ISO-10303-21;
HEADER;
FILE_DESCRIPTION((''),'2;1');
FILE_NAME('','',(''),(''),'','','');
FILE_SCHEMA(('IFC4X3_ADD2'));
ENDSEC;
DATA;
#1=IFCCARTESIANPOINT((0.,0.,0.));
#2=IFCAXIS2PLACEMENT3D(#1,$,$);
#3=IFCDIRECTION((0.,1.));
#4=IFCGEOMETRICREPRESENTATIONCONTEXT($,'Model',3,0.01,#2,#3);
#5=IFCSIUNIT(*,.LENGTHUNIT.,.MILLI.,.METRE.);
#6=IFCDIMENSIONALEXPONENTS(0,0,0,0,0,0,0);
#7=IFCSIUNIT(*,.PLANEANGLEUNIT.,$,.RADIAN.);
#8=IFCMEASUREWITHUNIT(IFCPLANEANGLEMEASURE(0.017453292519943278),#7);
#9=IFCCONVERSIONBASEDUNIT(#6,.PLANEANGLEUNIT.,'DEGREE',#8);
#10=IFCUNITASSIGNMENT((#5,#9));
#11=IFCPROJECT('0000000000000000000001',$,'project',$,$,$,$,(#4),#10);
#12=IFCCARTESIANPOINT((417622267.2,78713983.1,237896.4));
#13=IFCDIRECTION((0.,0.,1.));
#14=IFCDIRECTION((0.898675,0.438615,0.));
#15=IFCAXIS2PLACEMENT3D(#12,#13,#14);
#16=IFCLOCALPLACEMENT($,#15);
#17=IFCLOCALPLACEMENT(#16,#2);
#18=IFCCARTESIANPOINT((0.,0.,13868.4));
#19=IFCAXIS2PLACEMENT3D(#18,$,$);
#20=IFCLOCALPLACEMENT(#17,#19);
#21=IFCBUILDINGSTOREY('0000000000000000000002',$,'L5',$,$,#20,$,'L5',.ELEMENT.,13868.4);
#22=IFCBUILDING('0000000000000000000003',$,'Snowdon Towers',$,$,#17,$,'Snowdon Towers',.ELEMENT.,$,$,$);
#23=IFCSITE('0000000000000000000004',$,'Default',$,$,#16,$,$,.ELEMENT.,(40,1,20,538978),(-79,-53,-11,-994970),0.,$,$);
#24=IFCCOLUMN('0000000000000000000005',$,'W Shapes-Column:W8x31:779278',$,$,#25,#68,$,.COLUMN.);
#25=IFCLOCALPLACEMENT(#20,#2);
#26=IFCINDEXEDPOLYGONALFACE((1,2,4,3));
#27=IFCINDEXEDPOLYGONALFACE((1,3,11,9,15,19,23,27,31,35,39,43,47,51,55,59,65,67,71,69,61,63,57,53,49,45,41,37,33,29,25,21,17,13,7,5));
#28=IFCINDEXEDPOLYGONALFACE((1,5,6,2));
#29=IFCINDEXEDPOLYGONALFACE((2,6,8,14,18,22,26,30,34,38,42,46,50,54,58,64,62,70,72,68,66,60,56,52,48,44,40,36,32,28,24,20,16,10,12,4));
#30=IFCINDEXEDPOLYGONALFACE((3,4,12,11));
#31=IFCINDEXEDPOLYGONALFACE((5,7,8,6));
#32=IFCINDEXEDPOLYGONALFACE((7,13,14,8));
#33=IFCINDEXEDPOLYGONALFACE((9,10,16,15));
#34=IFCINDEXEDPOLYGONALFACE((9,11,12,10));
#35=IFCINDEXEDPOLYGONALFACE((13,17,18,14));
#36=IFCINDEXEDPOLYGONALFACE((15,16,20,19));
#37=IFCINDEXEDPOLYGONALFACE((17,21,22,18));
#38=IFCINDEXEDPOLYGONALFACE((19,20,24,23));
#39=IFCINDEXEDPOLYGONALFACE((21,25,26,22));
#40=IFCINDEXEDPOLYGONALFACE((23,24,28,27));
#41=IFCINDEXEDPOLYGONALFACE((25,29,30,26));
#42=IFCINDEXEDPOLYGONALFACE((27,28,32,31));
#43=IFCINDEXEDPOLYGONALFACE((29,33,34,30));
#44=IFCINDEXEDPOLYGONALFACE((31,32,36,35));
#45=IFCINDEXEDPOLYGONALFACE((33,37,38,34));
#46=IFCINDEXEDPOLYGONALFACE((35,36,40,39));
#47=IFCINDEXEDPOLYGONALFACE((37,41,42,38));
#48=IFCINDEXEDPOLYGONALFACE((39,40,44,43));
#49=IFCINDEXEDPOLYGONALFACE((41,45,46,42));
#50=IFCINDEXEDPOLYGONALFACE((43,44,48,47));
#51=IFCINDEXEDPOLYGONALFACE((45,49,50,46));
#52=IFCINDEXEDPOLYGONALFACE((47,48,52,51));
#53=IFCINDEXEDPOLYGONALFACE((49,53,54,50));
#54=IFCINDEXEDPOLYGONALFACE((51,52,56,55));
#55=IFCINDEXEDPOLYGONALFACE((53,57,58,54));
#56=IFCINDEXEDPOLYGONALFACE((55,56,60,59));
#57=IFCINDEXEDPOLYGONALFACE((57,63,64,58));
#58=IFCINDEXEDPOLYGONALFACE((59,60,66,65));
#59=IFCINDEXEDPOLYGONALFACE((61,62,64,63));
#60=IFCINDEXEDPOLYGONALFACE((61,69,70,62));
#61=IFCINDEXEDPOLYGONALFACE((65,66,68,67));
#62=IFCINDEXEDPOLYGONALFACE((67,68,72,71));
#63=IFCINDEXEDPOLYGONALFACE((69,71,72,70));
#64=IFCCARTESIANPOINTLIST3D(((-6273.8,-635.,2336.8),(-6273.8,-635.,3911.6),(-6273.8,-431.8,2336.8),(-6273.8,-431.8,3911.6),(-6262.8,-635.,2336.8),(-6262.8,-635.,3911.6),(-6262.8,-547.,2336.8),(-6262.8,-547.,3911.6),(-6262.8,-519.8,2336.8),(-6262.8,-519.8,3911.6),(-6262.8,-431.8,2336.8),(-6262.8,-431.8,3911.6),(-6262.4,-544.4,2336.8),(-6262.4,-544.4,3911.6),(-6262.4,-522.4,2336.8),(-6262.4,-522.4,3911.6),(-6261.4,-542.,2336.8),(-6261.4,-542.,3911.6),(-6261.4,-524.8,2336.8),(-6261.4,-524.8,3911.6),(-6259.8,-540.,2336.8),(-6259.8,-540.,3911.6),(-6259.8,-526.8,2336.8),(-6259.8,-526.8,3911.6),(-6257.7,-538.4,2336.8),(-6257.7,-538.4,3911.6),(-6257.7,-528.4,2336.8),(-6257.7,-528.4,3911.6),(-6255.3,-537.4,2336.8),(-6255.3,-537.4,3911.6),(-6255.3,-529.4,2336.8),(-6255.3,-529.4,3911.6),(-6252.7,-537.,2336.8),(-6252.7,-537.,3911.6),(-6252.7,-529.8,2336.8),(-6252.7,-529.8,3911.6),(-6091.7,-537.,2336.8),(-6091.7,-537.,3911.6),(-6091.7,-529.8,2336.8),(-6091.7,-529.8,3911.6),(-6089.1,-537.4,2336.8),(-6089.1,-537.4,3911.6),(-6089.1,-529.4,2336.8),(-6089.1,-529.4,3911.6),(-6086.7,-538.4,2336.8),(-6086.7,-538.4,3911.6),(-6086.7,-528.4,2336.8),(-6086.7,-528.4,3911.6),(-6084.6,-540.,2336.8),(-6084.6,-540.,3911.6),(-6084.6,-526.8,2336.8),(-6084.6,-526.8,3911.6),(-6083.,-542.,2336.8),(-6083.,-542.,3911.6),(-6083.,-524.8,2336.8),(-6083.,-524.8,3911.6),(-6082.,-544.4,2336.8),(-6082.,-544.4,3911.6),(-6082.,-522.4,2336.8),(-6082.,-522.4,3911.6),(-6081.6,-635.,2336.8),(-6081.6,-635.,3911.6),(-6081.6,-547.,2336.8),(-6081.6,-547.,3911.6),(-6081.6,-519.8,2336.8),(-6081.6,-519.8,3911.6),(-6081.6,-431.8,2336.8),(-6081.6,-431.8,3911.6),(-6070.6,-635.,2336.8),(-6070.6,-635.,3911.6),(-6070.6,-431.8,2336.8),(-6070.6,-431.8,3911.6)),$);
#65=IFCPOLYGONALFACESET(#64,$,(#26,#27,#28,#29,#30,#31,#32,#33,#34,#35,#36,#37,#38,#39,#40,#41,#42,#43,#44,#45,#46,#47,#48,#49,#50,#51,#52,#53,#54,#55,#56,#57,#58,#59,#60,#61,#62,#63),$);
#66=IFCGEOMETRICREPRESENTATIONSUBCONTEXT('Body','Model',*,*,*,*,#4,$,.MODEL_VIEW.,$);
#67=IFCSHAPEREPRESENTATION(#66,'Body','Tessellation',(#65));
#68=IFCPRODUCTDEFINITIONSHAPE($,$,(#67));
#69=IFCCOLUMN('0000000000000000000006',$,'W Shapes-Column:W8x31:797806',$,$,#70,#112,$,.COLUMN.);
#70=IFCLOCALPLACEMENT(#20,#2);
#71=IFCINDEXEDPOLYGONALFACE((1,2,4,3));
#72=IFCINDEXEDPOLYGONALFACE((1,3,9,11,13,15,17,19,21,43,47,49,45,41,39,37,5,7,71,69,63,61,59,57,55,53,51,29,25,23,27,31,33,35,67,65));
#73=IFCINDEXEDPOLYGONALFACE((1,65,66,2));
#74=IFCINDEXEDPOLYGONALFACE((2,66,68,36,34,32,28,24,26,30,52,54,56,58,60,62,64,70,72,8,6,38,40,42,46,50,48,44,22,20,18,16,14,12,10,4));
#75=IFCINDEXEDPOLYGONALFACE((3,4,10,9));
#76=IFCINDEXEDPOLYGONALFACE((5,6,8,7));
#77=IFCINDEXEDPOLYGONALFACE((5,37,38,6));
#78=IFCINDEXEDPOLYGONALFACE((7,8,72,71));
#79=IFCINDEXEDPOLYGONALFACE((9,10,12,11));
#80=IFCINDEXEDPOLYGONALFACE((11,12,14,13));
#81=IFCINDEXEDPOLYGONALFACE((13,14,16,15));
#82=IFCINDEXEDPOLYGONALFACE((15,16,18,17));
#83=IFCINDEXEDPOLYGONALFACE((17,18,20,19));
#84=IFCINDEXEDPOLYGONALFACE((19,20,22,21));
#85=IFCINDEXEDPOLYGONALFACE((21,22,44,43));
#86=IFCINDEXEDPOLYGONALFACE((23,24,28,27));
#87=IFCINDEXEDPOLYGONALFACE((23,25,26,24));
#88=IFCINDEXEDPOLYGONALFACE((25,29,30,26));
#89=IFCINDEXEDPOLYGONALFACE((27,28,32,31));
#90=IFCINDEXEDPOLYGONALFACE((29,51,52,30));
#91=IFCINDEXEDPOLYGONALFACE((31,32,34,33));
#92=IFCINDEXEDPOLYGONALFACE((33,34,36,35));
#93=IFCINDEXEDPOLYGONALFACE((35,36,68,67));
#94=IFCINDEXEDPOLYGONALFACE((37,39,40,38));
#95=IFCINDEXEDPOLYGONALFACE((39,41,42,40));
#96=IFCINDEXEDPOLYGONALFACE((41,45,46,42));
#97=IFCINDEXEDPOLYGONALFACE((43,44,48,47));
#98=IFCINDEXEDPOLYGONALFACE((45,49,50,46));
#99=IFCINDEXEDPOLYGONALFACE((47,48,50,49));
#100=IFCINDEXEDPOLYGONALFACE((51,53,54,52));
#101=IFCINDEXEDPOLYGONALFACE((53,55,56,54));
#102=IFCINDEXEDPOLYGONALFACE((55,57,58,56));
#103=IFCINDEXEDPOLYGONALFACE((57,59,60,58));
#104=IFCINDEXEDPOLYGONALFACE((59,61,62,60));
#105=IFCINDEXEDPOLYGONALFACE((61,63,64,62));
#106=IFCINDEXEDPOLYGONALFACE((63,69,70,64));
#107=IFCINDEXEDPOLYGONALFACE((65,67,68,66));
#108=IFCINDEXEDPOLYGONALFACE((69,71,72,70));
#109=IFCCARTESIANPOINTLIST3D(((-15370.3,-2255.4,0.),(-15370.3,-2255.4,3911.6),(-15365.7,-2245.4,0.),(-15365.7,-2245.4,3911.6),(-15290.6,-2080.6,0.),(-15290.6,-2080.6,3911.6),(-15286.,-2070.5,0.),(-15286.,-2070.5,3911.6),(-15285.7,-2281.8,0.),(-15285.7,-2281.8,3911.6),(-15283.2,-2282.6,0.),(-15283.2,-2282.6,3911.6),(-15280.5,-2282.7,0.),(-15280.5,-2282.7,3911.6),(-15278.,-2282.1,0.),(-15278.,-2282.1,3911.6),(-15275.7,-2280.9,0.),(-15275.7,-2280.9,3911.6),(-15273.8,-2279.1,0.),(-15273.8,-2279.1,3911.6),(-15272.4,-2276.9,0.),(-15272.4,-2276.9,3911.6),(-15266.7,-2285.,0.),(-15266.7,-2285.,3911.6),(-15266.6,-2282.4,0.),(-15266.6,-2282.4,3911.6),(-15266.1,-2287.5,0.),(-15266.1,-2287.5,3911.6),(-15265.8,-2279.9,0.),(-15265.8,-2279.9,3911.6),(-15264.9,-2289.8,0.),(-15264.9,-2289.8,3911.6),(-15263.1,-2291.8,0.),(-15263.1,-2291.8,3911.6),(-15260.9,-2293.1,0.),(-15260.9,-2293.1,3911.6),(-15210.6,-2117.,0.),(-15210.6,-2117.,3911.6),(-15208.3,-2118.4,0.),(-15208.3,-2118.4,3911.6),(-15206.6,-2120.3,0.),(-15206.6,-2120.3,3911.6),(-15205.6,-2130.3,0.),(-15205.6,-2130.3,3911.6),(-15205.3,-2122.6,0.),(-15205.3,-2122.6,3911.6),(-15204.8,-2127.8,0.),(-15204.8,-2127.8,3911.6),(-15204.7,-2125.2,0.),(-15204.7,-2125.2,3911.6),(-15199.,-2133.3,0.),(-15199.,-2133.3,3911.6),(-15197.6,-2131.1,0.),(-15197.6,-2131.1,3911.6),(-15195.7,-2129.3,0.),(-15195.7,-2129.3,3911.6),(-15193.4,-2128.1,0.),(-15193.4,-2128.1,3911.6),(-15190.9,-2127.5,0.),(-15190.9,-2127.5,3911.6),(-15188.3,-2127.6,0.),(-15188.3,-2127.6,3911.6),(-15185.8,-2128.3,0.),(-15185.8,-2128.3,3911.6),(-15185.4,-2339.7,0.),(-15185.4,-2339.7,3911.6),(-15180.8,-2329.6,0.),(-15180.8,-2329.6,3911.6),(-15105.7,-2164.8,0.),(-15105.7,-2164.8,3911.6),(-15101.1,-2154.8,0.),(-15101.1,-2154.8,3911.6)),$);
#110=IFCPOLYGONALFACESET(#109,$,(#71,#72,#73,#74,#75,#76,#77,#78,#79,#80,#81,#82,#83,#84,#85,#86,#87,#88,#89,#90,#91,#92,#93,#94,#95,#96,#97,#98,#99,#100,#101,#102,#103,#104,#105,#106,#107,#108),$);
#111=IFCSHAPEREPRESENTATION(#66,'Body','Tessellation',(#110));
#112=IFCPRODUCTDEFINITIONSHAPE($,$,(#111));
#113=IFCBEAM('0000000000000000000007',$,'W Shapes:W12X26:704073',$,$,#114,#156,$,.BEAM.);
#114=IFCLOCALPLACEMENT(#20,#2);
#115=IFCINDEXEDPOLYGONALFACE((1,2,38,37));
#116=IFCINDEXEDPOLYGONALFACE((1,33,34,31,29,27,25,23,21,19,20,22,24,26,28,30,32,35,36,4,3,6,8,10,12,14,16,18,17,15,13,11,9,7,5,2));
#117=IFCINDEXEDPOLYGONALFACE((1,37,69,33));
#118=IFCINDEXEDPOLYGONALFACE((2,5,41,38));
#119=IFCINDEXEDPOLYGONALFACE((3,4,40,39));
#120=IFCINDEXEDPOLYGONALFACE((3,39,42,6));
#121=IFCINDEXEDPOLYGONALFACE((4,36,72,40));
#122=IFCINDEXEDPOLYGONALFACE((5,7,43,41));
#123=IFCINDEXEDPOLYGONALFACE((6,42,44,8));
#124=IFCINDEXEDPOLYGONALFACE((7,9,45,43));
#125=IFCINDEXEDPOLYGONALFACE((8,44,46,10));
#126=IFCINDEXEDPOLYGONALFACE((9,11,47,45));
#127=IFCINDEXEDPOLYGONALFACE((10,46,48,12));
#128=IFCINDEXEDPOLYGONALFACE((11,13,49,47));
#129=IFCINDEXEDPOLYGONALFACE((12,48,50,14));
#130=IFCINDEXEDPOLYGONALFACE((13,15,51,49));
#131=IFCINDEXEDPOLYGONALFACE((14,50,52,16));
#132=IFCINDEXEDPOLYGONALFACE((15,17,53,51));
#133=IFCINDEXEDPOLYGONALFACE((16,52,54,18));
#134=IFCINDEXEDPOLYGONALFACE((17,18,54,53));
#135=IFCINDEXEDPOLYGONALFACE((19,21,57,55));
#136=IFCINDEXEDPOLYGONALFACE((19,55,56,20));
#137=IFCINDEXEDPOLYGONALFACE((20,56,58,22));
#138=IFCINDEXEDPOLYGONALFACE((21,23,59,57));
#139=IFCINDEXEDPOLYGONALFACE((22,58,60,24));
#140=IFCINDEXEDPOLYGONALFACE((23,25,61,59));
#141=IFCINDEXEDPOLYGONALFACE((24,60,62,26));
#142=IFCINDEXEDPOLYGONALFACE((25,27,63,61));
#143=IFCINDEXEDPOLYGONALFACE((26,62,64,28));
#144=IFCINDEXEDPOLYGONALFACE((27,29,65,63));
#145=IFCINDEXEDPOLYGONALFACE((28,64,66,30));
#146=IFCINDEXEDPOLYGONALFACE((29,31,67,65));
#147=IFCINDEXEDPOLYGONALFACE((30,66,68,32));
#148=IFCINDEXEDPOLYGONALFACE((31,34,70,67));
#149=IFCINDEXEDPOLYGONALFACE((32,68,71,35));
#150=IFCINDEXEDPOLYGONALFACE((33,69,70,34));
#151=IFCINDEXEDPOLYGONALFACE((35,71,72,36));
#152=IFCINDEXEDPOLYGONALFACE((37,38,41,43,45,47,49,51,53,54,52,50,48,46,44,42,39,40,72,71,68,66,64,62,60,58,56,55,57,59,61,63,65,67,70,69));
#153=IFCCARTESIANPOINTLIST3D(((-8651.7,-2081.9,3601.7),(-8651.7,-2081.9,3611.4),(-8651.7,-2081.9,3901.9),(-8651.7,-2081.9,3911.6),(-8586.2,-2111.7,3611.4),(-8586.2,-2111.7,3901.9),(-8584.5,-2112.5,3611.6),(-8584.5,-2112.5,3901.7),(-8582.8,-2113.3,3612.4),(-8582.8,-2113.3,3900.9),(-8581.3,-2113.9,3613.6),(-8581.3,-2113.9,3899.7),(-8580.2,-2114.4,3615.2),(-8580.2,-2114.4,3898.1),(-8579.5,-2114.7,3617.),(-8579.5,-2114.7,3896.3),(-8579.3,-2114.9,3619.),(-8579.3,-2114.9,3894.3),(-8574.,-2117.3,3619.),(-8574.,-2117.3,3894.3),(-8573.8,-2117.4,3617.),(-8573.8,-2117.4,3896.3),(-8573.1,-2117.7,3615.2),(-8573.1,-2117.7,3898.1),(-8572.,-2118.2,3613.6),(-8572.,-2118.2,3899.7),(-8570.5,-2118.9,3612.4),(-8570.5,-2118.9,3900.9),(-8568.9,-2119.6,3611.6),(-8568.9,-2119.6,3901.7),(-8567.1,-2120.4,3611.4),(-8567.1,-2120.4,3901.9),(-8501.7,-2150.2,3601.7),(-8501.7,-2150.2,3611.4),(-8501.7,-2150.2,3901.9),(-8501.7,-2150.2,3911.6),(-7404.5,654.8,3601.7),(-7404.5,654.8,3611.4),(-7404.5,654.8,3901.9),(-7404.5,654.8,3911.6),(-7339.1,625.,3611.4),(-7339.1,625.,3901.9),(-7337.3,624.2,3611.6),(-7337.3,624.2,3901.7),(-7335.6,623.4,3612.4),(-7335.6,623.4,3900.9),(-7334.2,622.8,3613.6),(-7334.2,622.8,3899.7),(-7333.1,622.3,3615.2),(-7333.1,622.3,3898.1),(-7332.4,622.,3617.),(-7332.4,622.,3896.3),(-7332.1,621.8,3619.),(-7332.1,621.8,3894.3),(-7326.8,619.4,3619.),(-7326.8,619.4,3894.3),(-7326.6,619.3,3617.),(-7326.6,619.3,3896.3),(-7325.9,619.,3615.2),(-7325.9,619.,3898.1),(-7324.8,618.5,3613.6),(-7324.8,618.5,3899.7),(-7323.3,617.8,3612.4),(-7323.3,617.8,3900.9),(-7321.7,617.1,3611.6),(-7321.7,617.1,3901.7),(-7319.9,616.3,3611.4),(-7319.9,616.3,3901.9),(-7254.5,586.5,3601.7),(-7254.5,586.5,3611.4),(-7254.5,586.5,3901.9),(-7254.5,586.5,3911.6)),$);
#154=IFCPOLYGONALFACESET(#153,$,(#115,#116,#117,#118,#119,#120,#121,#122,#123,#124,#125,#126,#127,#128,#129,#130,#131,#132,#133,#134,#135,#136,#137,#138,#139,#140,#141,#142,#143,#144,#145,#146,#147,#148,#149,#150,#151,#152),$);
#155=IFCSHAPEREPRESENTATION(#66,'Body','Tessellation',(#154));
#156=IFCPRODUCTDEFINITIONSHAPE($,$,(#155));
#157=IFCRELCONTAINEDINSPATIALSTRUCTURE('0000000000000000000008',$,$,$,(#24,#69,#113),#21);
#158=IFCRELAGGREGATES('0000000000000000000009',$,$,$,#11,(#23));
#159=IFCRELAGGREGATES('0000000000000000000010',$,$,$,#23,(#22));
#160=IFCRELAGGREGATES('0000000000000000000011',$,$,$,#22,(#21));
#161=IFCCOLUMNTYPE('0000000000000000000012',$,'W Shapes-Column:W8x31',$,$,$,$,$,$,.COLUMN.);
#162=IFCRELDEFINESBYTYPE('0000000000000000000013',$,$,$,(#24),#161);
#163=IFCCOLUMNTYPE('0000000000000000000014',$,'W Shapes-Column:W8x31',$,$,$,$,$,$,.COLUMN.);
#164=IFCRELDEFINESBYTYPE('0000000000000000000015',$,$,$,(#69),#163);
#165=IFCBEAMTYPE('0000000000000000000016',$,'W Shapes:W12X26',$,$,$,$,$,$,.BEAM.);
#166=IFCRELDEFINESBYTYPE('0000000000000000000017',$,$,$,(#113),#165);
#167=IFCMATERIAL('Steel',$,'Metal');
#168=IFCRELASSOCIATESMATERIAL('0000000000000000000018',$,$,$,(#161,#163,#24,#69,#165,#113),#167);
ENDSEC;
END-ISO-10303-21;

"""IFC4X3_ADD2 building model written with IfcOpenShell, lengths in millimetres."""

from ifc_helpers import new_model, entity, si_unit, converted_unit, direction, frame, frame_2d, origin, place, context, subcontext, project, spatial, polyline, circle_curve, parameter, trimmed, segment, composite_curve, i_section, outline, extrude, source, transform, mapped, material, material_profile, profile_set, profile_usage, type_object, type_shapes, element, save


model = new_model("IFC4X3_ADD2")

# Units and contexts
model_context = context("Model", 3, precision=0.01, world=origin(), true_north=direction((0.0, 1.0)))
body_context = subcontext(model_context, "Body", "Model", "MODEL_VIEW")
ifc_project = project(units=[si_unit("LENGTHUNIT", "METRE", prefix="MILLI"), converted_unit("PLANEANGLEUNIT", "DEGREE", entity("IfcPlaneAngleMeasure", 0.017453292519943278), si_unit("PLANEANGLEUNIT", "RADIAN"), dimensions=[0, 0, 0, 0, 0, 0, 0])], contexts=[model_context])

# Site, building, storey
site_placement = place(None, frame((417622267.2, 78713983.1, 237896.4), z_axis=(0.0, 0.0, 1.0), x_axis=(0.898675, 0.438615, 0.0)))
site = spatial("IfcSite", under=ifc_project, at=site_placement, Name="Default", CompositionType="ELEMENT", RefLatitude=(40, 1, 20, 538978), RefLongitude=(-79, -53, -11, -994970), RefElevation=0.0)
building_placement = place(site_placement, origin())
building = spatial("IfcBuilding", under=site, at=building_placement, Name="Snowdon Towers", LongName="Snowdon Towers", CompositionType="ELEMENT")
storey_placement = place(building_placement, frame((0.0, 0.0, 13868.4)))
storey = spatial("IfcBuildingStorey", under=building, at=storey_placement, Name="L5", LongName="L5", CompositionType="ELEMENT", Elevation=13868.4)

# Columns
ifc_material_1 = material(Name="Steel", Category="Metal")
ifc_material_profile_1 = material_profile(ifc_material_1, i_section(OverallWidth=203.2, OverallDepth=203.2, WebThickness=7.2, FlangeThickness=11.0, FilletRadius=10.0, at=frame_2d((0.0, 0.0), x_axis=(1.0, 0.0))), Name="W8x31")
ifc_profile_set_1 = profile_set([ifc_material_profile_1], Name="W8x31")
ifc_profile_usage_1 = profile_usage(ifc_profile_set_1)
column_type_1 = type_object("IfcColumnType", Name="W Shapes-Column:W8x31", PredefinedType="COLUMN", material=ifc_profile_set_1)
shared_shape_1 = source(origin(), body_context, "Body", "SweptSolid", [
    extrude(i_section(OverallWidth=203.2, OverallDepth=203.2, WebThickness=7.2, FlangeThickness=11.0, FilletRadius=10.0, at=frame_2d((0.0, 0.0), x_axis=(0.0, 1.0))), frame((0.0, 0.0, 16205.2), z_axis=(0.0, 0.0, 1.0), x_axis=(0.0, 1.0, 0.0)), (0.0, 0.0, 1.0), 1574.8),
])
type_shapes(column_type_1, [shared_shape_1])
column_1_placement = place(storey_placement, frame((-6172.2, -533.4, -13868.4), z_axis=(0.0, 0.0, 1.0), x_axis=(0.0, 1.0, 0.0)))
element("IfcColumn", 1, at=column_1_placement, inside=storey, type_object=column_type_1, material=ifc_profile_usage_1, Name="W Shapes-Column:W8x31:779278", PredefinedType="COLUMN", context=body_context, shape_type="MappedRepresentation", body=[
    mapped(shared_shape_1, transform((0.0, 0.0, 0.0), scale=1.0)),
])
column_type_2 = type_object("IfcColumnType", Name="W Shapes-Column:W8x31", PredefinedType="COLUMN", material=ifc_profile_set_1)
shared_shape_2 = source(origin(), body_context, "Body", "SweptSolid", [
    extrude(i_section(OverallWidth=203.2, OverallDepth=203.2, WebThickness=7.2, FlangeThickness=11.0, FilletRadius=10.0, at=frame_2d((0.0, 0.0), x_axis=(1.0, 0.0))), frame((-15235.7, -2205.1, 13868.4), z_axis=(0.0, 0.0, 1.0), x_axis=(-0.909961, 0.414693, 0.0)), (0.0, 0.0, 1.0), 3911.6),
])
type_shapes(column_type_2, [shared_shape_2])
column_2_placement = place(storey_placement, frame((0.0, 0.0, -13868.4)))
element("IfcColumn", 2, at=column_2_placement, inside=storey, type_object=column_type_2, material=ifc_profile_usage_1, Name="W Shapes-Column:W8x31:797806", PredefinedType="COLUMN", context=body_context, shape_type="MappedRepresentation", body=[
    mapped(shared_shape_2, transform((0.0, 0.0, 0.0), scale=1.0)),
])

# Beam
ifc_material_profile_2 = material_profile(ifc_material_1, outline(composite_curve([segment(polyline([(-82.4, -145.3), (-82.4, -154.9)]), True, "CONTINUOUS"), segment(polyline([(-82.4, -154.9), (82.4, -154.9)]), True, "CONTINUOUS"), segment(polyline([(82.4, -154.9), (82.4, -145.3)]), True, "CONTINUOUS"), segment(polyline([(82.4, -145.3), (10.5, -145.3)]), True, "CONTINUOUS"), segment(trimmed(circle_curve(frame_2d((10.5, -137.7), x_axis=(1.0, 0.0)), 7.6), [parameter(180.0)], [parameter(270.0)], True, "PARAMETER"), False, "CONTINUOUS"), segment(polyline([(2.9, -137.7), (2.9, 137.7)]), True, "CONTINUOUS"), segment(trimmed(circle_curve(frame_2d((10.5, 137.7), x_axis=(1.0, 0.0)), 7.6), [parameter(90.0)], [parameter(180.0)], True, "PARAMETER"), False, "CONTINUOUS"), segment(polyline([(10.5, 145.3), (82.4, 145.3)]), True, "CONTINUOUS"), segment(polyline([(82.4, 145.3), (82.4, 154.9)]), True, "CONTINUOUS"), segment(polyline([(82.4, 154.9), (-82.4, 154.9)]), True, "CONTINUOUS"), segment(polyline([(-82.4, 154.9), (-82.4, 145.3)]), True, "CONTINUOUS"), segment(polyline([(-82.4, 145.3), (-10.5, 145.3)]), True, "CONTINUOUS"), segment(trimmed(circle_curve(frame_2d((-10.5, 137.7), x_axis=(1.0, 0.0)), 7.6), [parameter(360.0)], [parameter(90.0)], True, "PARAMETER"), False, "CONTINUOUS"), segment(polyline([(-2.9, 137.7), (-2.9, -137.7)]), True, "CONTINUOUS"), segment(trimmed(circle_curve(frame_2d((-10.5, -137.7), x_axis=(1.0, 0.0)), 7.6), [parameter(270.0)], [parameter(360.0)], True, "PARAMETER"), False, "CONTINUOUS"), segment(polyline([(-10.5, -145.3), (-82.4, -145.3)]), True, "CONTINUOUS")], self_intersect=False)), Name="W12X26")
ifc_profile_set_2 = profile_set([ifc_material_profile_2], Name="W12X26")
ifc_profile_usage_2 = profile_usage(ifc_profile_set_2, cardinal=8)
beam_type_1 = type_object("IfcBeamType", Name="W Shapes:W12X26", PredefinedType="BEAM", material=ifc_profile_set_2)
shared_shape_3 = source(origin(), body_context, "Body", "SweptSolid", [
    extrude(outline(composite_curve([segment(polyline([(-82.4, -145.3), (-82.4, -154.9)]), True, "CONTINUOUS"), segment(polyline([(-82.4, -154.9), (82.4, -154.9)]), True, "CONTINUOUS"), segment(polyline([(82.4, -154.9), (82.4, -145.3)]), True, "CONTINUOUS"), segment(polyline([(82.4, -145.3), (10.5, -145.3)]), True, "CONTINUOUS"), segment(trimmed(circle_curve(frame_2d((10.5, -137.7), x_axis=(1.0, 0.0)), 7.6), [parameter(180.0)], [parameter(270.0)], True, "PARAMETER"), False, "CONTINUOUS"), segment(polyline([(2.9, -137.7), (2.9, 137.7)]), True, "CONTINUOUS"), segment(trimmed(circle_curve(frame_2d((10.5, 137.7), x_axis=(1.0, 0.0)), 7.6), [parameter(90.0)], [parameter(180.0)], True, "PARAMETER"), False, "CONTINUOUS"), segment(polyline([(10.5, 145.3), (82.4, 145.3)]), True, "CONTINUOUS"), segment(polyline([(82.4, 145.3), (82.4, 154.9)]), True, "CONTINUOUS"), segment(polyline([(82.4, 154.9), (-82.4, 154.9)]), True, "CONTINUOUS"), segment(polyline([(-82.4, 154.9), (-82.4, 145.3)]), True, "CONTINUOUS"), segment(polyline([(-82.4, 145.3), (-10.5, 145.3)]), True, "CONTINUOUS"), segment(trimmed(circle_curve(frame_2d((-10.5, 137.7), x_axis=(1.0, 0.0)), 7.6), [parameter(360.0)], [parameter(90.0)], True, "PARAMETER"), False, "CONTINUOUS"), segment(polyline([(-2.9, 137.7), (-2.9, -137.7)]), True, "CONTINUOUS"), segment(trimmed(circle_curve(frame_2d((-10.5, -137.7), x_axis=(1.0, 0.0)), 7.6), [parameter(270.0)], [parameter(360.0)], True, "PARAMETER"), False, "CONTINUOUS"), segment(polyline([(-10.5, -145.3), (-82.4, -145.3)]), True, "CONTINUOUS")], self_intersect=False)), frame((-1524.3, 0.0, 0.0), z_axis=(-1.0, 0.0, 0.0), x_axis=(0.0, -1.0, 0.0)), (0.0, 0.0, -1.0), 3007.5),
])
type_shapes(beam_type_1, [shared_shape_3])
beam_1_placement = place(storey_placement, frame((-7944.5, -729.0, 3756.7), z_axis=(0.0, 0.0, 1.0), x_axis=(0.414693, 0.909961, 0.0)))
element("IfcBeam", 3, at=beam_1_placement, inside=storey, type_object=beam_type_1, material=ifc_profile_usage_2, Name="W Shapes:W12X26:704073", PredefinedType="BEAM", context=body_context, shape_type="MappedRepresentation", body=[
    mapped(shared_shape_3, transform((0.0, 0.0, 0.0), scale=1.0)),
])

save(model, "model.ifc")
